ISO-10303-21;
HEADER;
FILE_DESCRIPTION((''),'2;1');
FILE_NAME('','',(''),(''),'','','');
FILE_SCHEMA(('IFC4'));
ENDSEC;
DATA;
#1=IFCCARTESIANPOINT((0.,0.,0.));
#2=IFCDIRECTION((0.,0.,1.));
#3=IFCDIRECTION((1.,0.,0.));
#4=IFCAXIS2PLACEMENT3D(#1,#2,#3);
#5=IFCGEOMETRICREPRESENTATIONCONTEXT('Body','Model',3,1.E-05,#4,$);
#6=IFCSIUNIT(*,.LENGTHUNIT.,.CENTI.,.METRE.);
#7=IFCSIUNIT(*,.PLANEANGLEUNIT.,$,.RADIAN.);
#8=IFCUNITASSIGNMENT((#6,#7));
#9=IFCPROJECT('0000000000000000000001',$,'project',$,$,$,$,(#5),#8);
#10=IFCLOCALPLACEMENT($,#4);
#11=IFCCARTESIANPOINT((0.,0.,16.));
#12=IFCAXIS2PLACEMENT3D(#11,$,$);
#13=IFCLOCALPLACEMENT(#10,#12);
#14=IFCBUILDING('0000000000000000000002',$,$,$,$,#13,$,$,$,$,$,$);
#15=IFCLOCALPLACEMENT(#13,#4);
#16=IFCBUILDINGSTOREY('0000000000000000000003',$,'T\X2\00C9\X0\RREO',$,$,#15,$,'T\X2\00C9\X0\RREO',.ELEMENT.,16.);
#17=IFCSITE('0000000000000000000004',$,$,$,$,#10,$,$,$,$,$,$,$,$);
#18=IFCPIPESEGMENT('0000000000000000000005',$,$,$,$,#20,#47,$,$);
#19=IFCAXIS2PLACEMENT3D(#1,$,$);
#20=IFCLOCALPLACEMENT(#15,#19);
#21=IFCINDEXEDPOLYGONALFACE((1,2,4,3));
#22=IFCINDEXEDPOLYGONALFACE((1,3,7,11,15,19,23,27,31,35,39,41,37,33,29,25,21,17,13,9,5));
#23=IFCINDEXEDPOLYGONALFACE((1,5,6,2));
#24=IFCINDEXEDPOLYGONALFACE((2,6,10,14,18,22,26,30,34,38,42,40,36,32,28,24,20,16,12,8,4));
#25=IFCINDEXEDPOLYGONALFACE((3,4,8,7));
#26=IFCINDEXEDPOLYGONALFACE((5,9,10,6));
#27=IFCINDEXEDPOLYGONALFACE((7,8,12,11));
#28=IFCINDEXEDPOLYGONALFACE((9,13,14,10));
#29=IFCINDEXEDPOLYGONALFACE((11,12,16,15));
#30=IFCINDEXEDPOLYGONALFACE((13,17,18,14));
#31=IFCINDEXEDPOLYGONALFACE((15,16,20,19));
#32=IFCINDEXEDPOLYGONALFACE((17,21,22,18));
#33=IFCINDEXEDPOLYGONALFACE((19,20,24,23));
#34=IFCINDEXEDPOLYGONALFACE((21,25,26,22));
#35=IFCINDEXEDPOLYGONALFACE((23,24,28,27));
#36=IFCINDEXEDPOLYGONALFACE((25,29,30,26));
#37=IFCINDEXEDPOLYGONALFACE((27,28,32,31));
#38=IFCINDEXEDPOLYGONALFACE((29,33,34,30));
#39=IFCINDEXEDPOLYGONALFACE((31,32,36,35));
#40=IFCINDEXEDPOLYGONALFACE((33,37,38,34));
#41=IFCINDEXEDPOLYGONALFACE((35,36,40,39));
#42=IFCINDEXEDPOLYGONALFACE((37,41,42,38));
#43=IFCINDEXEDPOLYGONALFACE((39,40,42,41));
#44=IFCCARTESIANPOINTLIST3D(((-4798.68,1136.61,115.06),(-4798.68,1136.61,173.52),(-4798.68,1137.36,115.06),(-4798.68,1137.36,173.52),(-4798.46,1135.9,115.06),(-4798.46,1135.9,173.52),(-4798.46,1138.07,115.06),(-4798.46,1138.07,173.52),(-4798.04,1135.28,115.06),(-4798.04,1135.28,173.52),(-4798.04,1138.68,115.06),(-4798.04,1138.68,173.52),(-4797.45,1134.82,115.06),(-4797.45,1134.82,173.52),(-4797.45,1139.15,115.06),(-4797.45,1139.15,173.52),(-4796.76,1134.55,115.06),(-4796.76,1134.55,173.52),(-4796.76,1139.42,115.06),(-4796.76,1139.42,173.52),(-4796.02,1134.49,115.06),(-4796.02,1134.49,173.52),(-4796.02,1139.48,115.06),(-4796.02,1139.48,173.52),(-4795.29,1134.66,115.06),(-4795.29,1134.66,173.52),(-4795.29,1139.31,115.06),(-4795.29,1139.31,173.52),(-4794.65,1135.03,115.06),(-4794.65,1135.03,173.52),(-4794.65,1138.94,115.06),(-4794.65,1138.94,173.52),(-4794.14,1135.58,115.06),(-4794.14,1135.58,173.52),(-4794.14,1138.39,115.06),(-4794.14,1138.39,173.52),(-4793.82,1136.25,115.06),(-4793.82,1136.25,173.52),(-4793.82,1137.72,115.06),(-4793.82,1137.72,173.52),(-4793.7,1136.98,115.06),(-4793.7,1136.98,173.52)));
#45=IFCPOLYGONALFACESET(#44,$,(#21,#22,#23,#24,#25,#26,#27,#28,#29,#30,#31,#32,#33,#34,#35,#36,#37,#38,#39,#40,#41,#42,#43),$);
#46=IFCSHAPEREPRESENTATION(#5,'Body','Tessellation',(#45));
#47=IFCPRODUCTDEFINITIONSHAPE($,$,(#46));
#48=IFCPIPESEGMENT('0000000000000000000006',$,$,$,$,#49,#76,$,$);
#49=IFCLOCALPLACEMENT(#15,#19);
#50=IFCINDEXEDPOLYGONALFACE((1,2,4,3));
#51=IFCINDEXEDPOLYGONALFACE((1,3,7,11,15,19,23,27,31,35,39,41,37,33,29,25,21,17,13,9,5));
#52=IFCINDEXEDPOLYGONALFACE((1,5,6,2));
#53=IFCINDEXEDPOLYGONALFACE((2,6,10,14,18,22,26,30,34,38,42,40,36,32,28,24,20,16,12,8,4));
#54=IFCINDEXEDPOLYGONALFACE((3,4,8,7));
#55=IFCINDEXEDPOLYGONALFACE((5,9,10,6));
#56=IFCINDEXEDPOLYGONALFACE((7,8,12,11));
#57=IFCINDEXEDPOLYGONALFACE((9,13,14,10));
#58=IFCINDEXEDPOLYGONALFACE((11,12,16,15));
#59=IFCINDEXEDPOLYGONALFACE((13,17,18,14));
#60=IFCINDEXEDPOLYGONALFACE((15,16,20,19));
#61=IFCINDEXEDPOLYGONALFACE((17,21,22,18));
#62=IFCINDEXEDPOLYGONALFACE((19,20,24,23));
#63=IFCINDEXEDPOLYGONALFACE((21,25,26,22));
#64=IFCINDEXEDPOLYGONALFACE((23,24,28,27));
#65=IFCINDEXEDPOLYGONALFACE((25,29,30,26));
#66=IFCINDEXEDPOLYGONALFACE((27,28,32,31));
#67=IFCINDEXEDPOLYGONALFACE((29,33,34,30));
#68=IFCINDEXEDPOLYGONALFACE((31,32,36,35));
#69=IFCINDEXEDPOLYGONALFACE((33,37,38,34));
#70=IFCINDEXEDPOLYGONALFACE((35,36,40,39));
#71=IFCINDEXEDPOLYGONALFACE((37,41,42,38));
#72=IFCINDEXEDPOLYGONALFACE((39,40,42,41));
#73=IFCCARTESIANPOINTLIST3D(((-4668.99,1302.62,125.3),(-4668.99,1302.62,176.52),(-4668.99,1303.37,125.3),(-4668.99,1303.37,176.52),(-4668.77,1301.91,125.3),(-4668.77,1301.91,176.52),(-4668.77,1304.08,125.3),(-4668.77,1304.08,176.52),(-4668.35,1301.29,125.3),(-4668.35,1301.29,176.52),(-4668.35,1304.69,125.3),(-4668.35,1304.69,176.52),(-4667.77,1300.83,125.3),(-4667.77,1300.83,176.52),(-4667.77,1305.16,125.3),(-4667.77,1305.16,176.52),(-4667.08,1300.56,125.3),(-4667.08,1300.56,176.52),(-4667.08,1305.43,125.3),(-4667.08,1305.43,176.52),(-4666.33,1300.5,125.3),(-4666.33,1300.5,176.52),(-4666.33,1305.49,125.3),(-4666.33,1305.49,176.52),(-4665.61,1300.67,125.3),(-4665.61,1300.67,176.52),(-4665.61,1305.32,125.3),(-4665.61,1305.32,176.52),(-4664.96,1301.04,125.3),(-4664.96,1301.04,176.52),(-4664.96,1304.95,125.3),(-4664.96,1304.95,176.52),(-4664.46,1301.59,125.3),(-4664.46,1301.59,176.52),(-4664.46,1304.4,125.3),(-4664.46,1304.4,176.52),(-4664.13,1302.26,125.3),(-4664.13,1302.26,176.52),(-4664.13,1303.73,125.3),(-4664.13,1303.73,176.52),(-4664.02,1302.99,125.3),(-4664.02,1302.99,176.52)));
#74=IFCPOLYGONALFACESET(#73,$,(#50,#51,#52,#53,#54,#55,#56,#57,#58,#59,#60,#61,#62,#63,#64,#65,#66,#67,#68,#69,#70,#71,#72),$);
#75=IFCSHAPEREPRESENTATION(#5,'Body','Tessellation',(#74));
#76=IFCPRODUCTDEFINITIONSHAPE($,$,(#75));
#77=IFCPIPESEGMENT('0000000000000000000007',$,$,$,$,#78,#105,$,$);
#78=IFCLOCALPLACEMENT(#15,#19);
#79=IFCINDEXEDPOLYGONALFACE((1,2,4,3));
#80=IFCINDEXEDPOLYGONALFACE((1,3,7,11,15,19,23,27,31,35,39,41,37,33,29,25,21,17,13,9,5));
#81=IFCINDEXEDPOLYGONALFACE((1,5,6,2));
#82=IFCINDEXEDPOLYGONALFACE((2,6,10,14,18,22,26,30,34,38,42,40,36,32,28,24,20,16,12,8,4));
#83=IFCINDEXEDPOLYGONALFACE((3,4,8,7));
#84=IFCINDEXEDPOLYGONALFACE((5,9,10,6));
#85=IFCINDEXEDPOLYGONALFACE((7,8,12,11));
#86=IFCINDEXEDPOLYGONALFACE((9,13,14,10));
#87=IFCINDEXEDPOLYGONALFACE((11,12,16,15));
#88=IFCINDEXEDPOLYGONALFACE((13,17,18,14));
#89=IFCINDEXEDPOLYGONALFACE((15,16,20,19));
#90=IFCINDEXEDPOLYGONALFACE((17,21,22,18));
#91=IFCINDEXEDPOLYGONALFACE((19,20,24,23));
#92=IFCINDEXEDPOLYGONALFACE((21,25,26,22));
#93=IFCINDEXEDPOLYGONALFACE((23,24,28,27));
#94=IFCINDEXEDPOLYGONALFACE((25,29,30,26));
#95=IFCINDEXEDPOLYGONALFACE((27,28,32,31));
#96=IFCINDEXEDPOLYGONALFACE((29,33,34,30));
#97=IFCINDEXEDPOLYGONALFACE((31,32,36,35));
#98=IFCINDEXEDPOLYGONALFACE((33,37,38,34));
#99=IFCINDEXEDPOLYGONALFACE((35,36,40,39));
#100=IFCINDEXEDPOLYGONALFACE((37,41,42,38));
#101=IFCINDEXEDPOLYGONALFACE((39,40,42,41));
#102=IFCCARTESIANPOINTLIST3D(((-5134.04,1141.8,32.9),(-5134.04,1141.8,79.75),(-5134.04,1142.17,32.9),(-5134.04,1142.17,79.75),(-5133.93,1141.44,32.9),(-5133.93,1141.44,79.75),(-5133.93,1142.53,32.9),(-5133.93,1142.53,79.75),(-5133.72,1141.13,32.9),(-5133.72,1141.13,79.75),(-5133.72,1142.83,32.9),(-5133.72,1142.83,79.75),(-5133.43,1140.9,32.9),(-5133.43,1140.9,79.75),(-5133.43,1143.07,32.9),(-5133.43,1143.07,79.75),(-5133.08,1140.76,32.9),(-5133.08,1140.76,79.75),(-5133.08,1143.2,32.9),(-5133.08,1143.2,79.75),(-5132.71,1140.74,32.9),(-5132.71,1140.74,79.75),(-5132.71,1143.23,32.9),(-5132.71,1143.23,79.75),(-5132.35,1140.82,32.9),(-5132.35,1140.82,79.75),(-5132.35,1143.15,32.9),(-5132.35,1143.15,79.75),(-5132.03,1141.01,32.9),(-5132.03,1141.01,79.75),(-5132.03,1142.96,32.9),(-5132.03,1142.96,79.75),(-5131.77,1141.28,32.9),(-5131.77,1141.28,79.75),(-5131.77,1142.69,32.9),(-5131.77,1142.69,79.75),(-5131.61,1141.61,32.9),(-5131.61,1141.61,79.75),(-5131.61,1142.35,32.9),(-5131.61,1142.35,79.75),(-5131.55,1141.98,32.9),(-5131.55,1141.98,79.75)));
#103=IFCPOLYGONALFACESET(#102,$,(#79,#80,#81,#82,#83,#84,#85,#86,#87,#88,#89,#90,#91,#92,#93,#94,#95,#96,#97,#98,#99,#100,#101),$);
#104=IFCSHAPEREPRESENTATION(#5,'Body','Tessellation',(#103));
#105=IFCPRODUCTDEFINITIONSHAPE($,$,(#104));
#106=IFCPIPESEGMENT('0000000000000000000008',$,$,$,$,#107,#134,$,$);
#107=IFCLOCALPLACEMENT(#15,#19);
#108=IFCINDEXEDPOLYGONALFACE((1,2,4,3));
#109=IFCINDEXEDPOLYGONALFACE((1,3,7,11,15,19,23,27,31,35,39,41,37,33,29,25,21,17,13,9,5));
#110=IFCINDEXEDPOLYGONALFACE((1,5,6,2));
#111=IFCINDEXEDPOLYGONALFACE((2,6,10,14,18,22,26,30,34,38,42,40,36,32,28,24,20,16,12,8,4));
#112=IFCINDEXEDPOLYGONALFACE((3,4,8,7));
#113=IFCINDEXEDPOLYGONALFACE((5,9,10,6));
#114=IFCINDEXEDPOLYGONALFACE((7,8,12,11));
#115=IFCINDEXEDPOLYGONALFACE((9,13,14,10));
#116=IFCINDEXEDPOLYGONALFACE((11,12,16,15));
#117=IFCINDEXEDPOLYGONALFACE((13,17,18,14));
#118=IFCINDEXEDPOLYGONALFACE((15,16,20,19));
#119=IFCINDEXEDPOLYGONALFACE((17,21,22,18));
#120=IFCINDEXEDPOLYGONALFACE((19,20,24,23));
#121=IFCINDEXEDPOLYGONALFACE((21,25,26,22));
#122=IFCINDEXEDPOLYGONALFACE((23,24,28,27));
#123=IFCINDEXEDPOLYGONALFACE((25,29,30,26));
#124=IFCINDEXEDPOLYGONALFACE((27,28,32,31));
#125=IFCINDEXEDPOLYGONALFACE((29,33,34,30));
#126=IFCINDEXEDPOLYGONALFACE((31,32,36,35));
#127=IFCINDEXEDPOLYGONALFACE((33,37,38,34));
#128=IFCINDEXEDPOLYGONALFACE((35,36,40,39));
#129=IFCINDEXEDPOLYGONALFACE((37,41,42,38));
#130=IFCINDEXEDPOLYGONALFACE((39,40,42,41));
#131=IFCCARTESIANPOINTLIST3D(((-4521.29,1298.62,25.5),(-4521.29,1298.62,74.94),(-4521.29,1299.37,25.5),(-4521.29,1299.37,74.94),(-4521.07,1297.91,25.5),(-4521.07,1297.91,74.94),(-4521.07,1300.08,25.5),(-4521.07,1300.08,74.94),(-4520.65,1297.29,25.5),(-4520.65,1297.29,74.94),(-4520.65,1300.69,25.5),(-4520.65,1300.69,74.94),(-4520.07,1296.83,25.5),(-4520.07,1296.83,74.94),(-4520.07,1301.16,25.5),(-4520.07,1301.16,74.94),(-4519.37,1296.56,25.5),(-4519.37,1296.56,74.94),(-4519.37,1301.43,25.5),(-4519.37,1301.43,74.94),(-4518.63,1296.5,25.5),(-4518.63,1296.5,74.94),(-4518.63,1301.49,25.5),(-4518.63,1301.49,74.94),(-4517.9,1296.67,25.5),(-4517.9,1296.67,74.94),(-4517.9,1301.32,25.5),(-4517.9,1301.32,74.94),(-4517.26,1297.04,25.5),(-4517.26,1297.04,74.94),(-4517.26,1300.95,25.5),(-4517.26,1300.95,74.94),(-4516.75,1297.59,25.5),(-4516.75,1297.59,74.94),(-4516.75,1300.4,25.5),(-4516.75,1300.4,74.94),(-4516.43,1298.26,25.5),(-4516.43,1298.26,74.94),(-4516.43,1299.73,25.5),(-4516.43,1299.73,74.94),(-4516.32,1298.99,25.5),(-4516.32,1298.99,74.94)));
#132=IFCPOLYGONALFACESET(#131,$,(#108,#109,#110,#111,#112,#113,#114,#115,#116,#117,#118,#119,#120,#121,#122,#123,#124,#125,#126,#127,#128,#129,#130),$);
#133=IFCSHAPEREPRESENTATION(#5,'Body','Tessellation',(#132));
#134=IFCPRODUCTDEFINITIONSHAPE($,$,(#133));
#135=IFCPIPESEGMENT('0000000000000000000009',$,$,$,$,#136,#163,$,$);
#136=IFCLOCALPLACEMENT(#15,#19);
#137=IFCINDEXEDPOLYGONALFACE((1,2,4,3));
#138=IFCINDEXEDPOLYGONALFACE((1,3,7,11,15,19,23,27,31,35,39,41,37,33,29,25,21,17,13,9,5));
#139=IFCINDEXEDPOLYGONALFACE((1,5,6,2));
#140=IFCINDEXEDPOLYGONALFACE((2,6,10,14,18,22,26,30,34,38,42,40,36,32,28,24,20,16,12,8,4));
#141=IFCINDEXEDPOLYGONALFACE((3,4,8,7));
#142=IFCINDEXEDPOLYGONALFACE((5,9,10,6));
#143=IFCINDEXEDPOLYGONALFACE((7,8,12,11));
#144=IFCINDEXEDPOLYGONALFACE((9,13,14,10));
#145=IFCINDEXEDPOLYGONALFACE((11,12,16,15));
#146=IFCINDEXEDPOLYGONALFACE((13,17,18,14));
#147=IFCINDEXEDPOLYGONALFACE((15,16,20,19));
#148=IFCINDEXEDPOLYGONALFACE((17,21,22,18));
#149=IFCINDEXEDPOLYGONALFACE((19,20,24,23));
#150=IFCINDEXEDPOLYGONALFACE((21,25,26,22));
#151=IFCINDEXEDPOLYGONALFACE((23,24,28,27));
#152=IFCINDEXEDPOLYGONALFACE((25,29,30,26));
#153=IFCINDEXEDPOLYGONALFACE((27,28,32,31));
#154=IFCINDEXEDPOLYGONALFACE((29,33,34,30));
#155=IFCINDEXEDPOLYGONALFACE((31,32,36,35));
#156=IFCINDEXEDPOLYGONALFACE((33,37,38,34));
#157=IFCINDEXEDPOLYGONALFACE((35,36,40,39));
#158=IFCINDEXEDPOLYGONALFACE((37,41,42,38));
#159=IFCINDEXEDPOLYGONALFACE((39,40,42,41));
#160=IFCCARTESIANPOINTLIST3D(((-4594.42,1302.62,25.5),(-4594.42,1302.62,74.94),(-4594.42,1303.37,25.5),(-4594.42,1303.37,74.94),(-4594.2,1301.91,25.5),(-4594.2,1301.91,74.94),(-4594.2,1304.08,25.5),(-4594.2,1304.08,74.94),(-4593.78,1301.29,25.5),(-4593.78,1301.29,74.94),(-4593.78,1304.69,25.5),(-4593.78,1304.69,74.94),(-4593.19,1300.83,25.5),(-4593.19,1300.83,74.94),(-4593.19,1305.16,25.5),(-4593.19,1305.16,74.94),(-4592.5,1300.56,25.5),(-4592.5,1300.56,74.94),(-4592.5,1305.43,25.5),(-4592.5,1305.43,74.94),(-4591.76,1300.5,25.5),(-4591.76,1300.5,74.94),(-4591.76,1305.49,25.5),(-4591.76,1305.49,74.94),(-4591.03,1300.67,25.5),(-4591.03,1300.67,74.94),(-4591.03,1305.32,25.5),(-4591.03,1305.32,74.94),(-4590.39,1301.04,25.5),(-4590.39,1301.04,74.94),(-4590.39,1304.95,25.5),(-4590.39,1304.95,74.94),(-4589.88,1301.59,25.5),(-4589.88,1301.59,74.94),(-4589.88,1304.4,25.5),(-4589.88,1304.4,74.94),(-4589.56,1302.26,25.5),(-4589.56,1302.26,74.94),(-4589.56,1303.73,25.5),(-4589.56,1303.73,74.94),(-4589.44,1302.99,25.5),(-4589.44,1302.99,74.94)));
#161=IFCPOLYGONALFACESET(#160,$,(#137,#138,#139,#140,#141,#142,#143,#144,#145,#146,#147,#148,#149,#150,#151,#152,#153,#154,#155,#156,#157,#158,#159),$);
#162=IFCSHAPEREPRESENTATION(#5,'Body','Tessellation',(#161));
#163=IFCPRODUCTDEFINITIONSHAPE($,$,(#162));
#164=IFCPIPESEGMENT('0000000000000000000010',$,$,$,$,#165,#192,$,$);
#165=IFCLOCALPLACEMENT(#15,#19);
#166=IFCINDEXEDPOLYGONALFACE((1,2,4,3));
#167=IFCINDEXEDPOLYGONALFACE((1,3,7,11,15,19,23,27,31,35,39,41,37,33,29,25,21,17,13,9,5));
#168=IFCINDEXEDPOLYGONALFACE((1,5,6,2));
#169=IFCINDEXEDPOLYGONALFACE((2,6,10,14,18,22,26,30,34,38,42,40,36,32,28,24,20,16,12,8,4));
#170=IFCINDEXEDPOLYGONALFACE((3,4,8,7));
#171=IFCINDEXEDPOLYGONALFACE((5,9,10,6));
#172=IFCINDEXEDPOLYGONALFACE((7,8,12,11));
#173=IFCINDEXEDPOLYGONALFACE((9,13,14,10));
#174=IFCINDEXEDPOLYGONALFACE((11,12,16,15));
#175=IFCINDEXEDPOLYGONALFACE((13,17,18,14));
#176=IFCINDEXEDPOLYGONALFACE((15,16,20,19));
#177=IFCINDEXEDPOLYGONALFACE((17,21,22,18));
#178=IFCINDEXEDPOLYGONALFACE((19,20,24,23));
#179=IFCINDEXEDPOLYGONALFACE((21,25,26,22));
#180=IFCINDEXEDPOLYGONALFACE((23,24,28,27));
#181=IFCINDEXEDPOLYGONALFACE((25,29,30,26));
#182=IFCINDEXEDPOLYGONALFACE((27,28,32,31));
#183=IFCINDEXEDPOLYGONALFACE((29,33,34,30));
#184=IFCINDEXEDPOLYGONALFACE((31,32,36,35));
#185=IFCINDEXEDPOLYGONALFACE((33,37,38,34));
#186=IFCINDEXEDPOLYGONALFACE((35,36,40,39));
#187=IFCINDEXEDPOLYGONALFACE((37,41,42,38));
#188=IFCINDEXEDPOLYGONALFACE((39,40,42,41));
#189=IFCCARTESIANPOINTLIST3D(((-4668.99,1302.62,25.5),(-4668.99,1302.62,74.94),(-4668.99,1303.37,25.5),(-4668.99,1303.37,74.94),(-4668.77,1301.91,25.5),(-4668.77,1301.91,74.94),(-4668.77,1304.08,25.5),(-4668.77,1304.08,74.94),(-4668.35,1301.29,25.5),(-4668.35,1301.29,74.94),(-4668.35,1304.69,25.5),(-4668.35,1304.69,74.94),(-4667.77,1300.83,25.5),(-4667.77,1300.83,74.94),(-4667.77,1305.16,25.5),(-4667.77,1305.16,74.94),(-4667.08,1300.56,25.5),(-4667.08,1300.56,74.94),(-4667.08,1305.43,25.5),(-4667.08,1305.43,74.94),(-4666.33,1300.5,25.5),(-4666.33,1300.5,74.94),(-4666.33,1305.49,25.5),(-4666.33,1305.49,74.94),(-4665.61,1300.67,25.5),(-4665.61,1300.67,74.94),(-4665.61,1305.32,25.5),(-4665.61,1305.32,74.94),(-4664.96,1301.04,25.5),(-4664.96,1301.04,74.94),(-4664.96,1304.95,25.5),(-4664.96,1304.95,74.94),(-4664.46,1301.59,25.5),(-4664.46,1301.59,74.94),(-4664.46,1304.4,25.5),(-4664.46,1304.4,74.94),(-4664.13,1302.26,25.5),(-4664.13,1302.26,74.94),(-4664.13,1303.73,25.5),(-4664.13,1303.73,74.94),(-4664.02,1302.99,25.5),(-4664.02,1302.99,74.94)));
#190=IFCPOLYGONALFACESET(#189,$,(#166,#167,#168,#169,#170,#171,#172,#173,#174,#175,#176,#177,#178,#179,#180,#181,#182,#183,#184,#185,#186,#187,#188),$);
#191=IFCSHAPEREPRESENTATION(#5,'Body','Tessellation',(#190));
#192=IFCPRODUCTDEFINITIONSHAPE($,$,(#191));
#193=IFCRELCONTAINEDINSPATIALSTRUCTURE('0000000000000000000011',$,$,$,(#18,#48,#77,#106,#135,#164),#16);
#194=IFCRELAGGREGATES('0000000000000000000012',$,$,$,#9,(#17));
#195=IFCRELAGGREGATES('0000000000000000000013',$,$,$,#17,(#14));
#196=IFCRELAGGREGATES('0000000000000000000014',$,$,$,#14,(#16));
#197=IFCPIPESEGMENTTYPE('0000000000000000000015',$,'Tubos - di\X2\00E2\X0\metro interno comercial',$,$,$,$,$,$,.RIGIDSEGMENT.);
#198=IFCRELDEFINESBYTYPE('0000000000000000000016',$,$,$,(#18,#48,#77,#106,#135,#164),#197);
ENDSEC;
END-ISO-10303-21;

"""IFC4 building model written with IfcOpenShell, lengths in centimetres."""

from ifc_helpers import new_model, si_unit, frame, origin_with_axes, origin_2d_with_axis, place, context, project, spatial, circle, extrude, type_object, element, save


model = new_model("IFC4")

# Units and contexts
model_context = context("Model", 3, precision=1e-05, world=origin_with_axes(), identifier="Body")
ifc_project = project(units=[si_unit("LENGTHUNIT", "METRE", prefix="CENTI"), si_unit("PLANEANGLEUNIT", "RADIAN")], contexts=[model_context])

# Site, building, storey
site_placement = place(None, origin_with_axes())
site = spatial("IfcSite", under=ifc_project, at=site_placement)
building_placement = place(site_placement, frame((0.0, 0.0, 16.0)))
building = spatial("IfcBuilding", under=site, at=building_placement)
storey_placement = place(building_placement, origin_with_axes())
storey = spatial("IfcBuildingStorey", under=building, at=storey_placement, Name="TÉRREO", LongName="TÉRREO", CompositionType="ELEMENT", Elevation=16.0)

# Pipe segments
pipe_segment_type = type_object("IfcPipeSegmentType", Name="Tubos - diâmetro interno comercial", PredefinedType="RIGIDSEGMENT")
pipe_segment_1_placement = place(storey_placement, frame((-4796.2, 1136.98, 173.52), z_axis=(0.0, 0.0, 1.0), x_axis=(1.0, 0.0, 0.0)))
element("IfcPipeSegment", 1, at=pipe_segment_1_placement, inside=storey, type_object=pipe_segment_type, context=model_context, shape_type="SolidModel", body=[
    extrude(circle(Radius=2.5, at=origin_2d_with_axis()), frame((0.0, 0.0, 0.0), z_axis=(0.0, 0.0, -1.0), x_axis=(1.0, 0.0, 0.0)), (0.0, 0.0, 1.0), 58.46),
])
pipe_segment_2_placement = place(storey_placement, frame((-4666.52, 1302.99, 176.52), z_axis=(0.0, 0.0, 1.0), x_axis=(1.0, 0.0, 0.0)))
element("IfcPipeSegment", 2, at=pipe_segment_2_placement, inside=storey, type_object=pipe_segment_type, context=model_context, shape_type="SolidModel", body=[
    extrude(circle(Radius=2.5, at=origin_2d_with_axis()), frame((0.0, 0.0, 0.0), z_axis=(0.0, 0.0, -1.0), x_axis=(1.0, 0.0, 0.0)), (0.0, 0.0, 1.0), 51.22),
])
pipe_segment_3_placement = place(storey_placement, frame((-5132.8, 1141.98, 79.75), z_axis=(0.0, 0.0, 1.0), x_axis=(1.0, 0.0, 0.0)))
element("IfcPipeSegment", 3, at=pipe_segment_3_placement, inside=storey, type_object=pipe_segment_type, context=model_context, shape_type="SolidModel", body=[
    extrude(circle(Radius=1.25, at=origin_2d_with_axis()), frame((0.0, 0.0, 0.0), z_axis=(0.0, 0.0, -1.0), x_axis=(1.0, 0.0, 0.0)), (0.0, 0.0, 1.0), 46.85),
])
for number, where, z_axis, x_axis in (
    (4, (-4518.82, 1298.99, 74.94), (0.0, 0.0, 1.0), (1.0, 0.0, 0.0)),
    (5, (-4591.94, 1302.99, 74.94), (0.0, 0.0, 1.0), (1.0, 0.0, 0.0)),
    (6, (-4666.52, 1302.99, 74.94), (0.0, 0.0, 1.0), (1.0, 0.0, 0.0)),
):
    element("IfcPipeSegment", number, at=place(storey_placement, frame(where, z_axis=z_axis, x_axis=x_axis)), inside=storey, type_object=pipe_segment_type, context=model_context, shape_type="SolidModel", body=[
        extrude(circle(Radius=2.5, at=origin_2d_with_axis()), frame((0.0, 0.0, 0.0), z_axis=(0.0, 0.0, -1.0), x_axis=(1.0, 0.0, 0.0)), (0.0, 0.0, 1.0), 49.44),
    ])

save(model, "model.ifc")
